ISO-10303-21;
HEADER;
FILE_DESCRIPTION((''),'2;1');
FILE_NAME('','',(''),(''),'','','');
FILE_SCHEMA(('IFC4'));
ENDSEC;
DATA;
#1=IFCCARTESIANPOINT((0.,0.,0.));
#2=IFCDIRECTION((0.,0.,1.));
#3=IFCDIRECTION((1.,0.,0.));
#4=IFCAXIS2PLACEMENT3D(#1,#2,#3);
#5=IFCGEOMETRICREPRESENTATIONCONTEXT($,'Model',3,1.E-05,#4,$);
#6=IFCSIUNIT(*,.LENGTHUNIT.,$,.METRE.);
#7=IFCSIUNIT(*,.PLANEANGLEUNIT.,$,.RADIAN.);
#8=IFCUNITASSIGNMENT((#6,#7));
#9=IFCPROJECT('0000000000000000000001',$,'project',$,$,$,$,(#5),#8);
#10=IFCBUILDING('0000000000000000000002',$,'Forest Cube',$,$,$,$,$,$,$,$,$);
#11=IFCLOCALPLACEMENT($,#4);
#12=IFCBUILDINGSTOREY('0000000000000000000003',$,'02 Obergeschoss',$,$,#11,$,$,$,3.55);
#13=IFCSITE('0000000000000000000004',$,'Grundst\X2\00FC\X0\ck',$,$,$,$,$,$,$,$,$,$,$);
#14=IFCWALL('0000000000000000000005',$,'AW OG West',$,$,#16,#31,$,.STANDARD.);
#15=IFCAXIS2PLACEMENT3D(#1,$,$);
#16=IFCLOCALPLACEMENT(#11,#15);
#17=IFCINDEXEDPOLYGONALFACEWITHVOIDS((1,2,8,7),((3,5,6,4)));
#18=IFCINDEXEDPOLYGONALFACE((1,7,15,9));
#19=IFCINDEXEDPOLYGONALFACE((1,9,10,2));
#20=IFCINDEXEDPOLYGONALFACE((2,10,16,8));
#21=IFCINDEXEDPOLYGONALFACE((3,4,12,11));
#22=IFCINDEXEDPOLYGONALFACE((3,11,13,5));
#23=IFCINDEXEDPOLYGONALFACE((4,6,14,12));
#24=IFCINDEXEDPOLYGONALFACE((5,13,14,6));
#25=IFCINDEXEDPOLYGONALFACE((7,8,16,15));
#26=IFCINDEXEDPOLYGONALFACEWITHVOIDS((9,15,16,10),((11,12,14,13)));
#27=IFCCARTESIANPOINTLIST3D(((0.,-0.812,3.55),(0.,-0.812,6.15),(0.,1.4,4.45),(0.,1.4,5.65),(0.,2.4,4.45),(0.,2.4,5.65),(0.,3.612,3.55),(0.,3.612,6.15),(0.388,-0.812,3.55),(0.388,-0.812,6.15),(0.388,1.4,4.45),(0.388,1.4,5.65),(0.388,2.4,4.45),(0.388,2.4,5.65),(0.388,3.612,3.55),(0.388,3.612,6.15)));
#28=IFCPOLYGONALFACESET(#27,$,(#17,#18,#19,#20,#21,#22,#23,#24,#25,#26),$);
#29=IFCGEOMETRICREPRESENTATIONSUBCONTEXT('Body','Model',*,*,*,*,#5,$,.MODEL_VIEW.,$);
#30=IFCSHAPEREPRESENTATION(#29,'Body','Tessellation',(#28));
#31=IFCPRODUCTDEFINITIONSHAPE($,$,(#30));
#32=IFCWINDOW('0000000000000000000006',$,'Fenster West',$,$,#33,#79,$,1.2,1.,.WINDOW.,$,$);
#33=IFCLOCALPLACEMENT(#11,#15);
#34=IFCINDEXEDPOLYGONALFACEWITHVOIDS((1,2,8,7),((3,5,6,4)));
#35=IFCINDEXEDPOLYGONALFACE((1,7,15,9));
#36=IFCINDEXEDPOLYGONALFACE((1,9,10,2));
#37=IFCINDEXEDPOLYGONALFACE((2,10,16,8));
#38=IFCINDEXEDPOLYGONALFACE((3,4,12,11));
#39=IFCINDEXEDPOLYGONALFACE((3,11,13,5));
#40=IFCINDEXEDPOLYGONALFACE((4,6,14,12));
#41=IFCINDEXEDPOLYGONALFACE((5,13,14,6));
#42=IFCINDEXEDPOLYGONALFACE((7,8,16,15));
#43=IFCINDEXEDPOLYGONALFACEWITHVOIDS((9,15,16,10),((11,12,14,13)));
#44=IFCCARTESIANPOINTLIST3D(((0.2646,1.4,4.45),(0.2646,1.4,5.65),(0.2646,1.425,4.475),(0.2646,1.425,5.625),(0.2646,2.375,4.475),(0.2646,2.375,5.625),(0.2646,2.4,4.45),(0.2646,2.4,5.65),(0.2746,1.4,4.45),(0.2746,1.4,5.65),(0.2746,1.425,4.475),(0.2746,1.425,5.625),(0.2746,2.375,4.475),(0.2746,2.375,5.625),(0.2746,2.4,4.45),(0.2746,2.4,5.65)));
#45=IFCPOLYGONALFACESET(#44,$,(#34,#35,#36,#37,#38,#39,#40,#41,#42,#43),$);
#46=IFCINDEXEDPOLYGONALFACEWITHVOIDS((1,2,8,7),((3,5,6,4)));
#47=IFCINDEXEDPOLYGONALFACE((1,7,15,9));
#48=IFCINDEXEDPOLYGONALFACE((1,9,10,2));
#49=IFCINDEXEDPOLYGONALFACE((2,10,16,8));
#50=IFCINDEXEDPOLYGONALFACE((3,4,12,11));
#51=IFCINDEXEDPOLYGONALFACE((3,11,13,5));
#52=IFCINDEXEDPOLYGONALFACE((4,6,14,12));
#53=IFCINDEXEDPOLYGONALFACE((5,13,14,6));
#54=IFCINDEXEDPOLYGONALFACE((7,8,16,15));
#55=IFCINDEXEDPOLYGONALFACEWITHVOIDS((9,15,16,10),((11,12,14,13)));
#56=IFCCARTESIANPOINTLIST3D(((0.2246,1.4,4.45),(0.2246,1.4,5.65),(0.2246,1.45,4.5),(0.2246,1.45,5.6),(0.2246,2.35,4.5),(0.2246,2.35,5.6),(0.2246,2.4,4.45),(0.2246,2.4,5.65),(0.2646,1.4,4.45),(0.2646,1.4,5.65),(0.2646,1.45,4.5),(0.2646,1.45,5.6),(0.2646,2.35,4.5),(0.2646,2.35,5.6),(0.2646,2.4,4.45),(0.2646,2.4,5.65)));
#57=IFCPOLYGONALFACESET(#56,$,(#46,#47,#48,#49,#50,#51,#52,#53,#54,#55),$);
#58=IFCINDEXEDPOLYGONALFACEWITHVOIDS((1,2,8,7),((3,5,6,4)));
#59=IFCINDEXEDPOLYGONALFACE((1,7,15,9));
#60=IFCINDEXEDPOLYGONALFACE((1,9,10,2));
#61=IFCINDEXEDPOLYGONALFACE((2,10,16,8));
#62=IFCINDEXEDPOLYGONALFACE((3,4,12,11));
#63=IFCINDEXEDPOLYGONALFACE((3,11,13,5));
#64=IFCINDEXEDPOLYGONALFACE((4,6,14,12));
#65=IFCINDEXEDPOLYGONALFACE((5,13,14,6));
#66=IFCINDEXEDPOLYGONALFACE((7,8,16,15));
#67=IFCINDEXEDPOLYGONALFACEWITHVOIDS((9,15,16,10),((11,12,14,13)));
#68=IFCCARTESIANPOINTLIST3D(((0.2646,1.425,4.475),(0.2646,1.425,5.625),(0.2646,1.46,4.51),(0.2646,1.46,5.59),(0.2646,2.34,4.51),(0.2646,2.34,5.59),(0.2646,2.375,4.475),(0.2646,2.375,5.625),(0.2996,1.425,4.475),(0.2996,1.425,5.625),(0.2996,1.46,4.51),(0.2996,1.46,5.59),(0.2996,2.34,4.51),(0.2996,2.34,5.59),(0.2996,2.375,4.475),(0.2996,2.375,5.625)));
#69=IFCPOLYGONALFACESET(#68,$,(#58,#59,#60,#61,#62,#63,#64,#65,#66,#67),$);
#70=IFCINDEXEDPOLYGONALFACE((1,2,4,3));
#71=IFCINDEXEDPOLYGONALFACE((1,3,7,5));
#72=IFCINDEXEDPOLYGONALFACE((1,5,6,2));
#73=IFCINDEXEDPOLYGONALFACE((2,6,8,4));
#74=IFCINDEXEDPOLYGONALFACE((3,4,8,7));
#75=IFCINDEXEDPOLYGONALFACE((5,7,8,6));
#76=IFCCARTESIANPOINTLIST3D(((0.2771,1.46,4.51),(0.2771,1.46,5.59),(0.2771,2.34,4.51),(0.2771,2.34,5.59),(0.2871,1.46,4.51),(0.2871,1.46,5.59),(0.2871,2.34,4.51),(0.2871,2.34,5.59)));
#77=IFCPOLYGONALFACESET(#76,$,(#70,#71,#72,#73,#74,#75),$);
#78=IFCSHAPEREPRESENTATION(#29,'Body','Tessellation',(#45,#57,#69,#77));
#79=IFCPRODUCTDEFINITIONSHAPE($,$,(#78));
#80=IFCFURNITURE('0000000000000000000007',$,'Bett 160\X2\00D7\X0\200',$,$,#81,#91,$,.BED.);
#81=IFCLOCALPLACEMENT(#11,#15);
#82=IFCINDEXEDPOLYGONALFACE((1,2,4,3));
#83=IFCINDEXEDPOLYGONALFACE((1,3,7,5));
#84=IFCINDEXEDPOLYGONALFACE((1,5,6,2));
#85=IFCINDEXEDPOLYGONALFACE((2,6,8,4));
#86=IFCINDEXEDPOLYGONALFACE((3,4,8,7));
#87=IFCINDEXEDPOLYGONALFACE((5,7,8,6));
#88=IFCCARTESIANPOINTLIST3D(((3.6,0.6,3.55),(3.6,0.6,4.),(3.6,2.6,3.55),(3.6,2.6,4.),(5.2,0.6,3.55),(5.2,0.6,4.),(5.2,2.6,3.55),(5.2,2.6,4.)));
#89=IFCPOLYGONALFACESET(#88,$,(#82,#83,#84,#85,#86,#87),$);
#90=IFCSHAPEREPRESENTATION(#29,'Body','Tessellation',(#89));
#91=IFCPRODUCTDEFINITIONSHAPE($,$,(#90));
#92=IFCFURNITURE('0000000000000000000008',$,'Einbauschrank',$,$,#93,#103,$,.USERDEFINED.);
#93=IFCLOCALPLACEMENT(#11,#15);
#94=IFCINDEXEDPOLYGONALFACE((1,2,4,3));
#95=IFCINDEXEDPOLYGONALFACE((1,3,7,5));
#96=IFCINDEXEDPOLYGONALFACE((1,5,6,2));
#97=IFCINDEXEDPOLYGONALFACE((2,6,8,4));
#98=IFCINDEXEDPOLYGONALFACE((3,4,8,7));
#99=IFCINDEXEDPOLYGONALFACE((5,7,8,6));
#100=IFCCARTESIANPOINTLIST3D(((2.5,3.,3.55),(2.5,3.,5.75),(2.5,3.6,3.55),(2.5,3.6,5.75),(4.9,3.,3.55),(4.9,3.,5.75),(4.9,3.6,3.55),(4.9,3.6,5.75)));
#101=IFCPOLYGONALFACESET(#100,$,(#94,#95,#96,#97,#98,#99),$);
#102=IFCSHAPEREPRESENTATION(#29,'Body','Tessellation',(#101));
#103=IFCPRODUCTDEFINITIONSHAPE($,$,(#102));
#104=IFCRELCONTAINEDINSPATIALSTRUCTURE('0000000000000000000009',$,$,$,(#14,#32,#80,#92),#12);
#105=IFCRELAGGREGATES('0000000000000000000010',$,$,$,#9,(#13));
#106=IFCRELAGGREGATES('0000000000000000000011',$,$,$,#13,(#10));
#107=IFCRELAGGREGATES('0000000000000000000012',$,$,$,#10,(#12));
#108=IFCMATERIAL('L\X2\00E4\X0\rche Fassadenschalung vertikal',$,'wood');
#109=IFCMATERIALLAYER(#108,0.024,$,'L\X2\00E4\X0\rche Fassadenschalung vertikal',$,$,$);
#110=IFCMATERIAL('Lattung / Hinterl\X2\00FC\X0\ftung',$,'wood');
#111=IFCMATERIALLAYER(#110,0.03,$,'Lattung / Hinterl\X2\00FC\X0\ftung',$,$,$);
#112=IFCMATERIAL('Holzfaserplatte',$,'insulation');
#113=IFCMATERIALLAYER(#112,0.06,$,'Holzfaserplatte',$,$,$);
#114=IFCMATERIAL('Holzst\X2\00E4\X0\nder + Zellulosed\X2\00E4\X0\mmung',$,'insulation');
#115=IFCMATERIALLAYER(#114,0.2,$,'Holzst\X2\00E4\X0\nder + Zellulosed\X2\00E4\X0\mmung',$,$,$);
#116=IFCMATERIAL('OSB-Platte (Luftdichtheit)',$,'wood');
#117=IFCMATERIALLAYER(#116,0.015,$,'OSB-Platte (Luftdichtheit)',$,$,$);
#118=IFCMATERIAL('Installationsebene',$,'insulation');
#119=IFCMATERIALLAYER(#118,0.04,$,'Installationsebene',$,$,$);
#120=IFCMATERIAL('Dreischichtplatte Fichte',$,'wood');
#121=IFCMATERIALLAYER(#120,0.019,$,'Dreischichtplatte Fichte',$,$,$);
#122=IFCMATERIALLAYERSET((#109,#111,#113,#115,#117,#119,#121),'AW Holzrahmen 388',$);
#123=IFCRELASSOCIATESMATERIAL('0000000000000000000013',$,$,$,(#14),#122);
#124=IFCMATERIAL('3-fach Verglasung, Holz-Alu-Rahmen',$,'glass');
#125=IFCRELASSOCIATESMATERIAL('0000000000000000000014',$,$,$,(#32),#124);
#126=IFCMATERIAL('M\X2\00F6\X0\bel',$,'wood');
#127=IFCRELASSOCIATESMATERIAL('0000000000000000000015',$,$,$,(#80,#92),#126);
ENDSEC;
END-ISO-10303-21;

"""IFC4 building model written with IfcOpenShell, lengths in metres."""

from ifc_helpers import new_model, si_unit, frame, origin_with_axes, place, context, subcontext, project, spatial, line, indexed_curve, outline, extrude, material, layer, layer_set, element, fill, save


model = new_model("IFC4")

# Units and contexts
model_context = context("Model", 3, precision=1e-05, world=origin_with_axes())
body_context = subcontext(model_context, "Body", "Model", "MODEL_VIEW")
ifc_project = project(units=[si_unit("LENGTHUNIT", "METRE"), si_unit("PLANEANGLEUNIT", "RADIAN")], contexts=[model_context])

# Site, building, storey
site = spatial("IfcSite", under=ifc_project, Name="Grundstück")
building = spatial("IfcBuilding", under=site, Name="Forest Cube")
storey_placement = place(None, origin_with_axes())
storey = spatial("IfcBuildingStorey", under=building, at=storey_placement, Name="02 Obergeschoss", Elevation=3.55)

# Wall, opening, window
ifc_material_1 = material(Name="Lärche Fassadenschalung vertikal", Category="wood")
ifc_layer_1 = layer(ifc_material_1, 0.024, Name="Lärche Fassadenschalung vertikal")
ifc_material_2 = material(Name="Lattung / Hinterlüftung", Category="wood")
ifc_layer_2 = layer(ifc_material_2, 0.03, Name="Lattung / Hinterlüftung")
ifc_material_3 = material(Name="Holzfaserplatte", Category="insulation")
ifc_layer_3 = layer(ifc_material_3, 0.06, Name="Holzfaserplatte")
ifc_material_4 = material(Name="Holzständer + Zellulosedämmung", Category="insulation")
ifc_layer_4 = layer(ifc_material_4, 0.2, Name="Holzständer + Zellulosedämmung")
ifc_material_5 = material(Name="OSB-Platte (Luftdichtheit)", Category="wood")
ifc_layer_5 = layer(ifc_material_5, 0.015, Name="OSB-Platte (Luftdichtheit)")
ifc_material_6 = material(Name="Installationsebene", Category="insulation")
ifc_layer_6 = layer(ifc_material_6, 0.04, Name="Installationsebene")
ifc_material_7 = material(Name="Dreischichtplatte Fichte", Category="wood")
ifc_layer_7 = layer(ifc_material_7, 0.019, Name="Dreischichtplatte Fichte")
ifc_layer_set_1 = layer_set([ifc_layer_1, ifc_layer_2, ifc_layer_3, ifc_layer_4, ifc_layer_5, ifc_layer_6, ifc_layer_7], Name="AW Holzrahmen 388")
ifc_material_8 = material(Name="3-fach Verglasung, Holz-Alu-Rahmen", Category="glass")
wall_1_placement = place(storey_placement, frame((0.0, 3.612, 3.55), z_axis=(0.0, 0.0, 1.0), x_axis=(0.0, -1.0, 0.0)))
wall_1 = element("IfcWall", 1, at=wall_1_placement, inside=storey, material=ifc_layer_set_1, Name="AW OG West", PredefinedType="STANDARD", context=body_context, shape_type="SweptSolid", body=[
    extrude(outline(indexed_curve([(0.0, 0.0), (0.0, 0.388), (4.424, 0.388), (4.424, 0.0), (0.0, 0.0)], self_intersect=False)), origin_with_axes(), (0.0, 0.0, 1.0), 2.6),
])
opening_1_placement = place(wall_1_placement, frame((1.212, -0.1, 0.9), z_axis=(0.0, 0.0, 1.0), x_axis=(1.0, 0.0, 0.0)))
opening_1 = element("IfcOpeningElement", 2, at=opening_1_placement, cuts=wall_1, context=body_context, shape_type="SweptSolid", body=[
    extrude(outline(indexed_curve([(0.0, 0.0), (0.0, 0.588), (1.0, 0.588), (1.0, 0.0), (0.0, 0.0)], self_intersect=False)), origin_with_axes(), (0.0, 0.0, 1.0), 1.2),
])
window_1_placement = place(storey_placement, frame((0.1746, 2.4, 4.45), z_axis=(0.0, 0.0, 1.0), x_axis=(0.0, -1.0, 0.0)))
window_1 = element("IfcWindow", 3, at=window_1_placement, inside=storey, material=ifc_material_8, Name="Fenster West", OverallHeight=1.2, OverallWidth=1.0, PredefinedType="WINDOW", context=body_context, shape_type="SweptSolid", body=[
    extrude(outline(indexed_curve([(0.0, 0.0), (1.0, 0.0), (1.0, 1.2), (0.0, 1.2)], segments=[line(1, 2, 3, 4, 1)]), holes=[indexed_curve([(0.025, 0.025), (0.975, 0.025), (0.975, 1.175), (0.025, 1.175)], segments=[line(1, 2, 3, 4, 1)])]), frame((0.0, 0.09, 0.0), z_axis=(0.0, -1.0, 0.0), x_axis=(1.0, 0.0, 0.0)), (0.0, 0.0, -1.0), 0.01),
    extrude(outline(indexed_curve([(0.0, 0.0), (1.0, 0.0), (1.0, 1.2), (0.0, 1.2)], segments=[line(1, 2, 3, 4, 1)]), holes=[indexed_curve([(0.05, 0.05), (0.95, 0.05), (0.95, 1.15), (0.05, 1.15)], segments=[line(1, 2, 3, 4, 1)])]), frame((0.0, 0.05, 0.0), z_axis=(0.0, -1.0, 0.0), x_axis=(1.0, 0.0, 0.0)), (0.0, 0.0, -1.0), 0.04),
    extrude(outline(indexed_curve([(0.0, 0.0), (0.95, 0.0), (0.95, 1.15), (0.0, 1.15)], segments=[line(1, 2, 3, 4, 1)]), holes=[indexed_curve([(0.035, 0.035), (0.915, 0.035), (0.915, 1.115), (0.035, 1.115)], segments=[line(1, 2, 3, 4, 1)])]), frame((0.025, 0.09, 0.025), z_axis=(0.0, -1.0, 0.0), x_axis=(1.0, 0.0, 0.0)), (0.0, 0.0, -1.0), 0.035),
    extrude(outline(indexed_curve([(0.035, 0.035), (0.915, 0.035), (0.915, 1.115), (0.035, 1.115)], segments=[line(1, 2, 3, 4, 1)])), frame((0.025, 0.1025, 0.025), z_axis=(0.0, -1.0, 0.0), x_axis=(1.0, 0.0, 0.0)), (0.0, 0.0, -1.0), 0.01),
])
fill(opening_1, window_1)

# Furniture
ifc_material_9 = material(Name="Möbel", Category="wood")
furniture_1_placement = place(storey_placement, frame((0.0, 0.0, 3.55), z_axis=(0.0, 0.0, 1.0), x_axis=(1.0, 0.0, 0.0)))
element("IfcFurniture", 4, at=furniture_1_placement, inside=storey, material=ifc_material_9, Name="Bett 160×200", PredefinedType="BED", context=body_context, shape_type="SweptSolid", body=[
    extrude(outline(indexed_curve([(3.6, 0.6), (5.2, 0.6), (5.2, 2.6), (3.6, 2.6)])), None, (0.0, 0.0, 1.0), 0.45),
])
furniture_2_placement = place(storey_placement, frame((0.0, 0.0, 3.55), z_axis=(0.0, 0.0, 1.0), x_axis=(1.0, 0.0, 0.0)))
element("IfcFurniture", 5, at=furniture_2_placement, inside=storey, material=ifc_material_9, Name="Einbauschrank", PredefinedType="USERDEFINED", context=body_context, shape_type="SweptSolid", body=[
    extrude(outline(indexed_curve([(2.5, 3.0), (4.9, 3.0), (4.9, 3.6), (2.5, 3.6)])), None, (0.0, 0.0, 1.0), 2.2),
])

save(model, "model.ifc")
